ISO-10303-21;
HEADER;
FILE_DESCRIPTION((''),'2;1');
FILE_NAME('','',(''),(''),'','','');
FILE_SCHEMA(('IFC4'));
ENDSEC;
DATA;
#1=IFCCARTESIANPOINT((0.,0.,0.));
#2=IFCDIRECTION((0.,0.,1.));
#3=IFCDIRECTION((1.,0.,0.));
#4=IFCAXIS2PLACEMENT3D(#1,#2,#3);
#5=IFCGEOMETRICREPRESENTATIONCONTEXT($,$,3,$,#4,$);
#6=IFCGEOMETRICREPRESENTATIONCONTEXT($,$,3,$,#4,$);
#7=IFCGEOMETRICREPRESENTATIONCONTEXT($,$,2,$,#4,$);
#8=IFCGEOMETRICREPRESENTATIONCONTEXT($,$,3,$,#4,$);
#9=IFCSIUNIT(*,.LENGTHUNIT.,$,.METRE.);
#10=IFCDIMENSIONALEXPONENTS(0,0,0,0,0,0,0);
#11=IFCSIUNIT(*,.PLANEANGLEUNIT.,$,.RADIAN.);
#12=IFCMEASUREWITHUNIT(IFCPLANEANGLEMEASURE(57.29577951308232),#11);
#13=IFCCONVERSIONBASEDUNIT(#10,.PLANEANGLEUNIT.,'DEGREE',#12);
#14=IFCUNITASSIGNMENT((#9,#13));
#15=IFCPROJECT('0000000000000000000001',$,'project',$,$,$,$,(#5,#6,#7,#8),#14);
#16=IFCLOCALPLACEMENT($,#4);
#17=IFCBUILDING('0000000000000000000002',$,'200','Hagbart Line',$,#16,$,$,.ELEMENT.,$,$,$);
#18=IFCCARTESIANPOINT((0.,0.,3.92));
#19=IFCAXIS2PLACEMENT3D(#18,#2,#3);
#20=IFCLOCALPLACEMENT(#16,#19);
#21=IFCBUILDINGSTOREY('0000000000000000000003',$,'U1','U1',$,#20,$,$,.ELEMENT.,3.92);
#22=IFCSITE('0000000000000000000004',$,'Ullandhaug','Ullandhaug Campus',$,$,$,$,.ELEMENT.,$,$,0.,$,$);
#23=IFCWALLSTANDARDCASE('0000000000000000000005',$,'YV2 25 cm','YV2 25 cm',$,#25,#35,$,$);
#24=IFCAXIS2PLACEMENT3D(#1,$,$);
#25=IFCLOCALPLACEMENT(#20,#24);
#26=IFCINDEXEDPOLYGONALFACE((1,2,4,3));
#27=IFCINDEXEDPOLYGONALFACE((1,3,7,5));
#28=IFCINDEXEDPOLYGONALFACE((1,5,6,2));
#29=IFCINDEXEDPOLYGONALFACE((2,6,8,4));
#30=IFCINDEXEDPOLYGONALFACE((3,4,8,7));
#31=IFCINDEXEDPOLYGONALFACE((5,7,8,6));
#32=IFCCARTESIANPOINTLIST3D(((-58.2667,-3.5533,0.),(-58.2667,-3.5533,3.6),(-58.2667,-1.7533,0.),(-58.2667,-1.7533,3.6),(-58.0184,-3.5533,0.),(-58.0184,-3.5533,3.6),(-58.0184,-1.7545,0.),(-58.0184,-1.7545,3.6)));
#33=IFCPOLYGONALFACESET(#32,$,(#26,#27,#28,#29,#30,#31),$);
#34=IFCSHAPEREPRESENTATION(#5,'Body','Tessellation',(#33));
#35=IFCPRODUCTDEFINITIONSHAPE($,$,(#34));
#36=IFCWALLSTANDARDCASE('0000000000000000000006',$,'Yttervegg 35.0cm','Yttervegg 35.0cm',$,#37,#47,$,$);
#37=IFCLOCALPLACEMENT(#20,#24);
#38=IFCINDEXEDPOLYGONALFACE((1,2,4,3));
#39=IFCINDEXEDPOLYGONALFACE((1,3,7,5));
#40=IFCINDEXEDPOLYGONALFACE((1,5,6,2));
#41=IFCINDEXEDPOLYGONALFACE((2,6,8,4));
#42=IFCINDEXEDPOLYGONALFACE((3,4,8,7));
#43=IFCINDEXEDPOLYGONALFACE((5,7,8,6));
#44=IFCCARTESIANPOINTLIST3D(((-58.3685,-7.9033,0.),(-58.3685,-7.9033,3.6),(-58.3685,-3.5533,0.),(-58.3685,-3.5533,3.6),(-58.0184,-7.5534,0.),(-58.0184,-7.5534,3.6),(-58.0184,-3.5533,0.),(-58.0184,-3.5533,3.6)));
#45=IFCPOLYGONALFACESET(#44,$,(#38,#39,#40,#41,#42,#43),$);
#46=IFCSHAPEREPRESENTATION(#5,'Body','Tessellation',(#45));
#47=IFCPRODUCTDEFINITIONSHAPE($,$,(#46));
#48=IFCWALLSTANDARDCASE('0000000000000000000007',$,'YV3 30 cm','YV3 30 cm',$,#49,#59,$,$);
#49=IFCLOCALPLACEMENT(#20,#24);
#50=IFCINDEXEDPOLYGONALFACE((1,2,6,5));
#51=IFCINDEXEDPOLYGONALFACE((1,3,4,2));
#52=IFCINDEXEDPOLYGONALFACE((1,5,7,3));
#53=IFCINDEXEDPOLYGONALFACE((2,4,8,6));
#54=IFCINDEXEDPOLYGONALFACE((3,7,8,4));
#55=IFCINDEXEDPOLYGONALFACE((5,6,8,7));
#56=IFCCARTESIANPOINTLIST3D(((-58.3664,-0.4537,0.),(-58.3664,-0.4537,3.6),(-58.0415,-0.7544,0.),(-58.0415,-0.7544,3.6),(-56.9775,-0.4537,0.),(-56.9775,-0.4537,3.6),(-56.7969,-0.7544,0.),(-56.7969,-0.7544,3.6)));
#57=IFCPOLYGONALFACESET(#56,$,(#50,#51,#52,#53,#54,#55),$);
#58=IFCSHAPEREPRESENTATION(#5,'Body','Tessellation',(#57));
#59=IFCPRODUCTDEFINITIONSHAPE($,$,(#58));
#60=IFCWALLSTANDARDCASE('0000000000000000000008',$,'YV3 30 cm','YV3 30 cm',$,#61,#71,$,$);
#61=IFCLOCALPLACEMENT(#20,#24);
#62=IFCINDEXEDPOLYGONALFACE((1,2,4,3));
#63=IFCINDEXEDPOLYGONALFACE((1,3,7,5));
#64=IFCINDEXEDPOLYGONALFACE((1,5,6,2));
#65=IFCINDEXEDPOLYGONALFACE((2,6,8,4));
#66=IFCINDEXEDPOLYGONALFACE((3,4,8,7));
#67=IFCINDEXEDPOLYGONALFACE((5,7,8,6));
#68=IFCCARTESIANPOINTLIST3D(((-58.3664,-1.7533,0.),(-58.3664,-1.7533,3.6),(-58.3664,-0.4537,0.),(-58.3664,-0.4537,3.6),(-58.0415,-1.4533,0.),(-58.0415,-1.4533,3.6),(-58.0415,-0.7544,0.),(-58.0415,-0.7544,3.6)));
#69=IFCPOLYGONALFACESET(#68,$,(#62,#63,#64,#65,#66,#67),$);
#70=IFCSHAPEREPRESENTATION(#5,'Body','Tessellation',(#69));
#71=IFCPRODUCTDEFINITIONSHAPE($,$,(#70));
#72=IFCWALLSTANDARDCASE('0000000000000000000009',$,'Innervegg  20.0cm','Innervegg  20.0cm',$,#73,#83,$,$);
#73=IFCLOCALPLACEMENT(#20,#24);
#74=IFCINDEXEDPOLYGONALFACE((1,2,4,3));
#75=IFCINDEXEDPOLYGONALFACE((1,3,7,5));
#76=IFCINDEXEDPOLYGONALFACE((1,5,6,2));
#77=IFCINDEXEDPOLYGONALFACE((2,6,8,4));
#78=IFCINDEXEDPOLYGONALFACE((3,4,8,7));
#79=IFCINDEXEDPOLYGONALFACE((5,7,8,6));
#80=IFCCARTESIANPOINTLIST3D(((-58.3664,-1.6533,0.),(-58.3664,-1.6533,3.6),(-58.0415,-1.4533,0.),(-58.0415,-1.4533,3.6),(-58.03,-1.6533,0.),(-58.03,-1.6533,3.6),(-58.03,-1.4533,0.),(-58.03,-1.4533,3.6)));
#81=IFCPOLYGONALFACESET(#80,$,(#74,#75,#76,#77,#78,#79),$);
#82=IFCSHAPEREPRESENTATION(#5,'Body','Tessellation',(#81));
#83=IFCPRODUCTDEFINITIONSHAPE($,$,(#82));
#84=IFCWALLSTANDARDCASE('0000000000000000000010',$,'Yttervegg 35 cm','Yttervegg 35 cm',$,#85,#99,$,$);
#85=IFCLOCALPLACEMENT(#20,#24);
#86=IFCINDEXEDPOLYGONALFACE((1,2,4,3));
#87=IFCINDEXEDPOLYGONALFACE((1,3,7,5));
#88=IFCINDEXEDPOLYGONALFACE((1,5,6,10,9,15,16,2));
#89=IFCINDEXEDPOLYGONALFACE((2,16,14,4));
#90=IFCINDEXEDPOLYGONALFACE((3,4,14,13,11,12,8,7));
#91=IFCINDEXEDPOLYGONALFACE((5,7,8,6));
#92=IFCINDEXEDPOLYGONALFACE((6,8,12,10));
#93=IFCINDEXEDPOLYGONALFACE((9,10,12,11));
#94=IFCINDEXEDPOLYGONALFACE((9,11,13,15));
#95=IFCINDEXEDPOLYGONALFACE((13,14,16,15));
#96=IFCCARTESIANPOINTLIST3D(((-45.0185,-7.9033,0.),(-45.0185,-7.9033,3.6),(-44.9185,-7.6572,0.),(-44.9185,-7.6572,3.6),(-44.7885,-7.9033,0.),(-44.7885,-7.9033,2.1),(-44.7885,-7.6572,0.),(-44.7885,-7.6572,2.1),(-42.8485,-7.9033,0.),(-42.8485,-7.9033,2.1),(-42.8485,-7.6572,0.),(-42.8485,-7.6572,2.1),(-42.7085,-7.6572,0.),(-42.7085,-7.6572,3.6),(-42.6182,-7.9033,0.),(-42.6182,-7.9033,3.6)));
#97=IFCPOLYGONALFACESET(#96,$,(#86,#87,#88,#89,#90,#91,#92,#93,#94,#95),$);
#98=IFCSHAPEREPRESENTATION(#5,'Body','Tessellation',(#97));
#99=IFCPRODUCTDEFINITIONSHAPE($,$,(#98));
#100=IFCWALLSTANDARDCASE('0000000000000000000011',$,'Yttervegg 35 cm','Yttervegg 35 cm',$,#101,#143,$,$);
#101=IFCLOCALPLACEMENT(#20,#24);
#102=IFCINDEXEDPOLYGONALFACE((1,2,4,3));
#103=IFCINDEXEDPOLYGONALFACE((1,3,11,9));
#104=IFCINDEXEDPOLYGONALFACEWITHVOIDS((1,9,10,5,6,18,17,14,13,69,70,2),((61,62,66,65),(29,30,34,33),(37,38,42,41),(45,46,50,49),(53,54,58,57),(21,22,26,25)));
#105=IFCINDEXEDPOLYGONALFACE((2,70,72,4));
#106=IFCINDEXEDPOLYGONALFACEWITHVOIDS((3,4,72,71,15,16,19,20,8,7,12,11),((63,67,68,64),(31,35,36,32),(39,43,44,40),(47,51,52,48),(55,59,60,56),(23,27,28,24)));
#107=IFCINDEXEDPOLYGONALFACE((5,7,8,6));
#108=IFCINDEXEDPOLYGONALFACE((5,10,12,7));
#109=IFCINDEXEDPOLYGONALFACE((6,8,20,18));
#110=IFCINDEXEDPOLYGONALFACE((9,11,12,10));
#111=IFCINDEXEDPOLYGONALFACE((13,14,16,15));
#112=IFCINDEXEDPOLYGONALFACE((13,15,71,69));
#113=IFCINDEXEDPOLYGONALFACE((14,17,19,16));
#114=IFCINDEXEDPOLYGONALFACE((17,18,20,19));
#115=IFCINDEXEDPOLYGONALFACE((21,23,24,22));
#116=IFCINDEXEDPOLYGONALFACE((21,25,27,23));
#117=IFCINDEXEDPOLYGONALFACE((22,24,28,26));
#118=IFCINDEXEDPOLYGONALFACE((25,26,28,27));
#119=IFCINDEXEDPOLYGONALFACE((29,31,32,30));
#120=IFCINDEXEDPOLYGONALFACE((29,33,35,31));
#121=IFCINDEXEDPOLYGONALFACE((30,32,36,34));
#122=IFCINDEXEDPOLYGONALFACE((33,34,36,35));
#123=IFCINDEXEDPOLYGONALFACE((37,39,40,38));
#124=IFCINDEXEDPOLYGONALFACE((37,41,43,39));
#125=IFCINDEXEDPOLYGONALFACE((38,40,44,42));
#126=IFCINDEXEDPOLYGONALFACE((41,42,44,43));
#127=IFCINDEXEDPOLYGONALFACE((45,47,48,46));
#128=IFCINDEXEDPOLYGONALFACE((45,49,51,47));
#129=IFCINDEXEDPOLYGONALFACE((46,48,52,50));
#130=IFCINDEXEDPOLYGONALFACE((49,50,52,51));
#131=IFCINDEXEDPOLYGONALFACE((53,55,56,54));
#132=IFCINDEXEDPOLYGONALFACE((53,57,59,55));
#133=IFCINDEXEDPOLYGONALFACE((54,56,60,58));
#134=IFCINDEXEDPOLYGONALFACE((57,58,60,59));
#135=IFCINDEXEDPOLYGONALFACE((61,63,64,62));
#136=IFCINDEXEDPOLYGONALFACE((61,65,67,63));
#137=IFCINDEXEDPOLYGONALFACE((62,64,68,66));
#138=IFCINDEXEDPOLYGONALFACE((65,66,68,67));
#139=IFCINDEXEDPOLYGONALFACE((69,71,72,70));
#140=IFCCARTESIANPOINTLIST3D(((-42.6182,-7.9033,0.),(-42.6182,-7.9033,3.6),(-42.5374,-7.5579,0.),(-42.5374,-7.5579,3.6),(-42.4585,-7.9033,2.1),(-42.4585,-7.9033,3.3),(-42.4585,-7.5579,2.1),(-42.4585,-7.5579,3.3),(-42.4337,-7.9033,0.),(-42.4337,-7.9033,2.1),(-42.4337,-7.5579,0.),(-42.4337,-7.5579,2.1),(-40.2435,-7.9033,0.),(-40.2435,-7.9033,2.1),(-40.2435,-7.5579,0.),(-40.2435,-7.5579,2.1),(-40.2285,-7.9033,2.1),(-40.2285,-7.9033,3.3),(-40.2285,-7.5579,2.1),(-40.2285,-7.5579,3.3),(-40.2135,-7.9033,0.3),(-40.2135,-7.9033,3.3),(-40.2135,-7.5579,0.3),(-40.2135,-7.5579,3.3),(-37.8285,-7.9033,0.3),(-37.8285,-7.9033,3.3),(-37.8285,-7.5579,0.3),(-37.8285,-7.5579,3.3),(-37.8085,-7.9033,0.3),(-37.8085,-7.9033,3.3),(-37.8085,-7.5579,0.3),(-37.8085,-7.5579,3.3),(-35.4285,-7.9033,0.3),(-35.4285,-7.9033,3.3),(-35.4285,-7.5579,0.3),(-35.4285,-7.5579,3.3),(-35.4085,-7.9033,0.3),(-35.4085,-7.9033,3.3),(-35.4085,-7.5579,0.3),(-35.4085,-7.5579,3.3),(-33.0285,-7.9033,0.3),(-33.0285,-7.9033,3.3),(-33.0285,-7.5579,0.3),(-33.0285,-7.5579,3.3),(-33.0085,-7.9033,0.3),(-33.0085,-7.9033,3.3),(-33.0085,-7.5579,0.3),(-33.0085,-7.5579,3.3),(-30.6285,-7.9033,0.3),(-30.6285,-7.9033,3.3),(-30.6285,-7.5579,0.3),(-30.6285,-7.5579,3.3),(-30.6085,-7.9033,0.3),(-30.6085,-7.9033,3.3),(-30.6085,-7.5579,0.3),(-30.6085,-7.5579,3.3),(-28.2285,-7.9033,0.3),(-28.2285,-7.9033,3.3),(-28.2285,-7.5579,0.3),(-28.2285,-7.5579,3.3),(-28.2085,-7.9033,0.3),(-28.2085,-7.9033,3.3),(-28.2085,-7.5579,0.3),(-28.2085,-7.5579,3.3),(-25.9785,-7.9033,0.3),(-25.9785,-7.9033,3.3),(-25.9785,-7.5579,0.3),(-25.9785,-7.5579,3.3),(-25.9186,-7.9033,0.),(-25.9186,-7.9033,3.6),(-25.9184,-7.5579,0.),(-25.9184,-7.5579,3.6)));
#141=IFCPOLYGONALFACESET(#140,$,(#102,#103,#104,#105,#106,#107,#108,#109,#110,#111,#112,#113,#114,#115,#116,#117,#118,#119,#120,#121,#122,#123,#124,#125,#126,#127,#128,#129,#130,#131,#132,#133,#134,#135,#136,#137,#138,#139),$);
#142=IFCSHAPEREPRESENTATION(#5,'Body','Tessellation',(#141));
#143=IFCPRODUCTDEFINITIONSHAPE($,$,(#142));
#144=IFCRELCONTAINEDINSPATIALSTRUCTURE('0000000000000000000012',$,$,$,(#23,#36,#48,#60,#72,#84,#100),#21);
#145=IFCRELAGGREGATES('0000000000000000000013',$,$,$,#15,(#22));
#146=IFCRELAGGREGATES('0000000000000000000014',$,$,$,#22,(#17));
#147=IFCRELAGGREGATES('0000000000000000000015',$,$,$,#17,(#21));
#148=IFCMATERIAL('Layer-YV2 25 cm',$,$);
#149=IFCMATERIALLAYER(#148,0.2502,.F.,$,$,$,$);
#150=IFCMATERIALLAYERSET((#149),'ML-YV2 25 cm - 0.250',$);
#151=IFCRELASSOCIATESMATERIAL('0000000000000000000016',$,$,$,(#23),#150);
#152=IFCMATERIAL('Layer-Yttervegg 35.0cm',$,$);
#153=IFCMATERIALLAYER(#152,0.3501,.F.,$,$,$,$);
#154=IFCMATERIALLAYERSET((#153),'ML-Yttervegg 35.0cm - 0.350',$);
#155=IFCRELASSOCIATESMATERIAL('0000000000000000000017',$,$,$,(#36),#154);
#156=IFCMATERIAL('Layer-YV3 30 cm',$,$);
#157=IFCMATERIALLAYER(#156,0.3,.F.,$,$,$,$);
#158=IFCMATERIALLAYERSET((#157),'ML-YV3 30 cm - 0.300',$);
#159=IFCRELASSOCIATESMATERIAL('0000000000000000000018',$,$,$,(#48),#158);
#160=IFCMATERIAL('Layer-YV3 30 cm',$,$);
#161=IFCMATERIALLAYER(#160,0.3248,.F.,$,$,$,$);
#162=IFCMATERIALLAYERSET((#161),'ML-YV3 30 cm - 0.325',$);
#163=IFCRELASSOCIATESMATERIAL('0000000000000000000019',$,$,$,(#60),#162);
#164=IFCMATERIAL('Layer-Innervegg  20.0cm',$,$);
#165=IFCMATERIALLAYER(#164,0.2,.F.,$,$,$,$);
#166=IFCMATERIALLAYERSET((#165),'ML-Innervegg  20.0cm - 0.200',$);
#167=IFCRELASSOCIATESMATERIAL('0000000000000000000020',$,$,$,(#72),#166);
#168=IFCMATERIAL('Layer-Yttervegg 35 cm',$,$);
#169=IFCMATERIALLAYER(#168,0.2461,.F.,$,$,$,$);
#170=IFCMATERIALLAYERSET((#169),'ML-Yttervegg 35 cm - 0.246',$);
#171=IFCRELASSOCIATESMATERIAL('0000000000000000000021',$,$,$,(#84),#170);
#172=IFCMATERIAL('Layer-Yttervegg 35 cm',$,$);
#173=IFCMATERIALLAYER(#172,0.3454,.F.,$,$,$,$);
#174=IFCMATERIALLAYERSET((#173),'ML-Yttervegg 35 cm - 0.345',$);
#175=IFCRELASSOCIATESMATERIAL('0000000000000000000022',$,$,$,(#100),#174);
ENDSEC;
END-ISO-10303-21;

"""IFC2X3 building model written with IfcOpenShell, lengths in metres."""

from ifc_helpers import new_model, entity, si_unit, converted_unit, frame, origin_with_axes, place, context, project, spatial, polyline, outline, extrude, material, layer, layer_set, layer_usage, element, save


model = new_model("IFC2X3")

# Units and contexts
context_of_model_1 = context(None, 3, world=origin_with_axes())
context_of_model_2 = context(None, 3, world=origin_with_axes())
context_of_model_3 = context(None, 2, world=origin_with_axes())
context_of_model_4 = context(None, 3, world=origin_with_axes())
ifc_project = project(units=[si_unit("LENGTHUNIT", "METRE"), converted_unit("PLANEANGLEUNIT", "DEGREE", entity("IfcPlaneAngleMeasure", 57.29577951308232), si_unit("PLANEANGLEUNIT", "RADIAN"), dimensions=[0, 0, 0, 0, 0, 0, 0])], contexts=[context_of_model_1, context_of_model_2, context_of_model_3, context_of_model_4])

# Site, building, storey
site = spatial("IfcSite", under=ifc_project, Name="Ullandhaug", Description="Ullandhaug Campus", CompositionType="ELEMENT", RefElevation=0.0)
building_placement = place(None, origin_with_axes())
building = spatial("IfcBuilding", under=site, at=building_placement, Name="200", Description="Hagbart Line", CompositionType="ELEMENT")
storey_placement = place(building_placement, frame((0.0, 0.0, 3.92), z_axis=(0.0, 0.0, 1.0), x_axis=(1.0, 0.0, 0.0)))
storey = spatial("IfcBuildingStorey", under=building, at=storey_placement, Name="U1", Description="U1", CompositionType="ELEMENT", Elevation=3.92)

# Shared definitions
ifc_material_1 = material(Name="Layer-YV3 30 cm")
ifc_layer_1 = layer(ifc_material_1, 0.3, ventilated=False)
ifc_layer_set_1 = layer_set([ifc_layer_1], Name="ML-YV3 30 cm - 0.300")
ifc_layer_usage_1 = layer_usage(ifc_layer_set_1, "AXIS2", "POSITIVE", 0.0)
ifc_material_2 = material(Name="Layer-YV2 25 cm")
ifc_layer_2 = layer(ifc_material_2, 0.2502, ventilated=False)
ifc_layer_set_2 = layer_set([ifc_layer_2], Name="ML-YV2 25 cm - 0.250")
ifc_layer_usage_2 = layer_usage(ifc_layer_set_2, "AXIS2", "POSITIVE", 0.0)
ifc_material_3 = material(Name="Layer-Innervegg  20.0cm")
ifc_layer_3 = layer(ifc_material_3, 0.2, ventilated=False)
ifc_layer_set_3 = layer_set([ifc_layer_3], Name="ML-Innervegg  20.0cm - 0.200")
ifc_layer_usage_3 = layer_usage(ifc_layer_set_3, "AXIS2", "POSITIVE", 0.0)

# Walls
wall_1_placement = place(storey_placement, frame((-58.2667, -1.7533, 0.0), z_axis=(0.0, 0.0, 1.0), x_axis=(0.0, -1.0, 0.0)))
element("IfcWallStandardCase", 1, at=wall_1_placement, inside=storey, material=ifc_layer_usage_2, Name="YV2 25 cm", Description="YV2 25 cm", context=context_of_model_1, shape_type="SweptSolid", body=[
    extrude(outline(polyline([(0.0, 0.0), (1.8, 0.0), (1.8, 0.2483), (0.0012, 0.2483), (0.0, 0.0)])), frame((0.0, 0.0, 0.0), z_axis=(0.0, 0.0, 1.0), x_axis=(1.0, 0.0, 0.0)), (0.0, 0.0, 1.0), 3.6),
])
ifc_material_4 = material(Name="Layer-Yttervegg 35.0cm")
ifc_layer_4 = layer(ifc_material_4, 0.3501, ventilated=False)
ifc_layer_set_4 = layer_set([ifc_layer_4], Name="ML-Yttervegg 35.0cm - 0.350")
ifc_layer_usage_4 = layer_usage(ifc_layer_set_4, "AXIS2", "POSITIVE", 0.0)
wall_2_placement = place(storey_placement, frame((-58.3685, -3.5533, 0.0), z_axis=(0.0, 0.0, 1.0), x_axis=(0.0, -1.0, 0.0)))
element("IfcWallStandardCase", 2, at=wall_2_placement, inside=storey, material=ifc_layer_usage_4, Name="Yttervegg 35.0cm", Description="Yttervegg 35.0cm", context=context_of_model_1, shape_type="SweptSolid", body=[
    extrude(outline(polyline([(0.0, 0.0), (4.35, 0.0), (4.0001, 0.3501), (0.0, 0.3501), (0.0, 0.0)])), frame((0.0, 0.0, 0.0), z_axis=(0.0, 0.0, 1.0), x_axis=(1.0, 0.0, 0.0)), (0.0, 0.0, 1.0), 3.6),
])
wall_3_placement = place(storey_placement, frame((-56.9775, -0.4537, 0.0), z_axis=(0.0, 0.0, 1.0), x_axis=(-1.0, 0.0, 0.0)))
element("IfcWallStandardCase", 3, at=wall_3_placement, inside=storey, material=ifc_layer_usage_1, Name="YV3 30 cm", Description="YV3 30 cm", context=context_of_model_1, shape_type="SweptSolid", body=[
    extrude(outline(polyline([(0.0, 0.0), (1.3889, 0.0), (1.0641, 0.3008), (-0.1805, 0.3008), (0.0, 0.0)])), frame((0.0, 0.0, 0.0), z_axis=(0.0, 0.0, 1.0), x_axis=(1.0, 0.0, 0.0)), (0.0, 0.0, 1.0), 3.6),
])
ifc_material_5 = material(Name="Layer-YV3 30 cm")
ifc_layer_5 = layer(ifc_material_5, 0.3248, ventilated=False)
ifc_layer_set_5 = layer_set([ifc_layer_5], Name="ML-YV3 30 cm - 0.325")
ifc_layer_usage_5 = layer_usage(ifc_layer_set_5, "AXIS2", "POSITIVE", 0.0)
wall_4_placement = place(storey_placement, frame((-58.3664, -0.4537, 0.0), z_axis=(0.0, 0.0, 1.0), x_axis=(0.0, -1.0, 0.0)))
element("IfcWallStandardCase", 4, at=wall_4_placement, inside=storey, material=ifc_layer_usage_5, Name="YV3 30 cm", Description="YV3 30 cm", context=context_of_model_1, shape_type="SweptSolid", body=[
    extrude(outline(polyline([(0.0, 0.0), (1.2996, 0.0), (0.9996, 0.3248), (0.3008, 0.3248), (0.0, 0.0)])), frame((0.0, 0.0, 0.0), z_axis=(0.0, 0.0, 1.0), x_axis=(1.0, 0.0, 0.0)), (0.0, 0.0, 1.0), 3.6),
])
wall_5_placement = place(storey_placement, frame((-58.3664, -1.6533, 0.0), z_axis=(0.0, 0.0, 1.0), x_axis=(1.0, 0.0, 0.0)))
element("IfcWallStandardCase", 5, at=wall_5_placement, inside=storey, material=ifc_layer_usage_3, Name="Innervegg  20.0cm", Description="Innervegg  20.0cm", context=context_of_model_1, shape_type="SweptSolid", body=[
    extrude(outline(polyline([(0.0, 0.0), (0.3364, 0.0), (0.3364, 0.2), (0.3248, 0.2), (0.0, 0.0)])), origin_with_axes(), (0.0, 0.0, 1.0), 3.6),
])

# Wall, opening
ifc_material_6 = material(Name="Layer-Yttervegg 35 cm")
ifc_layer_6 = layer(ifc_material_6, 0.2461, ventilated=False)
ifc_layer_set_6 = layer_set([ifc_layer_6], Name="ML-Yttervegg 35 cm - 0.246")
ifc_layer_usage_6 = layer_usage(ifc_layer_set_6, "AXIS2", "POSITIVE", 0.0)
wall_6_placement = place(storey_placement, frame((-45.0185, -7.9033, 0.0), z_axis=(0.0, 0.0, 1.0), x_axis=(1.0, 0.0, 0.0)))
wall_6 = element("IfcWallStandardCase", 6, at=wall_6_placement, inside=storey, material=ifc_layer_usage_6, Name="Yttervegg 35 cm", Description="Yttervegg 35 cm", context=context_of_model_1, shape_type="SweptSolid", body=[
    extrude(outline(polyline([(0.0, 0.0), (2.4003, 0.0), (2.31, 0.2461), (0.1, 0.2461), (0.0, 0.0)])), origin_with_axes(), (0.0, 0.0, 1.0), 3.6),
])
opening_1_placement = place(wall_6_placement, frame((0.2299, 0.2461, 0.0), z_axis=(0.0, 0.0, 1.0), x_axis=(1.0, 0.0, 0.0)))
element("IfcOpeningElement", 7, at=opening_1_placement, cuts=wall_6, context=context_of_model_1, shape_type="SweptSolid", body=[
    extrude(outline(polyline([(0.0, 0.0), (2.1, 0.0), (2.1, 1.94), (0.0, 1.94), (0.0, 0.0)])), frame((0.0, 0.0, 0.0), z_axis=(0.0, 1.0, 0.0), x_axis=(0.0, 0.0, 1.0)), (0.0, 0.0, -1.0), 0.2461),
])

# Wall, openings
ifc_material_7 = material(Name="Layer-Yttervegg 35 cm")
ifc_layer_7 = layer(ifc_material_7, 0.3454, ventilated=False)
ifc_layer_set_7 = layer_set([ifc_layer_7], Name="ML-Yttervegg 35 cm - 0.345")
ifc_layer_usage_7 = layer_usage(ifc_layer_set_7, "AXIS2", "POSITIVE", 0.0)
wall_7_placement = place(storey_placement, frame((-42.6182, -7.9033, 0.0), z_axis=(0.0, 0.0, 1.0), x_axis=(1.0, 0.0, 0.0)))
wall_7 = element("IfcWallStandardCase", 8, at=wall_7_placement, inside=storey, material=ifc_layer_usage_7, Name="Yttervegg 35 cm", Description="Yttervegg 35 cm", context=context_of_model_1, shape_type="SweptSolid", body=[
    extrude(outline(polyline([(0.0, 0.0), (16.6996, 0.0), (16.6998, 0.3454), (0.0808, 0.3454), (0.0, 0.0)])), origin_with_axes(), (0.0, 0.0, 1.0), 3.6),
])
opening_2_placement = place(wall_7_placement, frame((0.1845, 0.3454, 0.0), z_axis=(0.0, 0.0, 1.0), x_axis=(1.0, 0.0, 0.0)))
element("IfcOpeningElement", 9, at=opening_2_placement, cuts=wall_7, context=context_of_model_1, shape_type="SweptSolid", body=[
    extrude(outline(polyline([(0.0, 0.0), (2.1, 0.0), (2.1, 2.1902), (0.0, 2.1902), (0.0, 0.0)])), frame((0.0, 0.0, 0.0), z_axis=(0.0, 1.0, 0.0), x_axis=(0.0, 0.0, 1.0)), (0.0, 0.0, -1.0), 0.3454),
])
opening_3_placement = place(wall_7_placement, frame((0.1597, 0.3454, 2.1), z_axis=(0.0, 0.0, 1.0), x_axis=(1.0, 0.0, 0.0)))
element("IfcOpeningElement", 10, at=opening_3_placement, cuts=wall_7, context=context_of_model_1, shape_type="SweptSolid", body=[
    extrude(outline(polyline([(0.0, 0.0), (1.2, 0.0), (1.2, 2.23), (0.0, 2.23), (0.0, 0.0)])), frame((0.0, 0.0, 0.0), z_axis=(0.0, 1.0, 0.0), x_axis=(0.0, 0.0, 1.0)), (0.0, 0.0, -1.0), 0.3454),
])
opening_4_placement = place(wall_7_placement, frame((2.4047, 0.3454, 0.3), z_axis=(0.0, 0.0, 1.0), x_axis=(1.0, 0.0, 0.0)))
element("IfcOpeningElement", 11, at=opening_4_placement, cuts=wall_7, context=context_of_model_1, shape_type="SweptSolid", body=[
    extrude(outline(polyline([(0.0, 0.0), (3.0, 0.0), (3.0, 2.385), (0.0, 2.385), (0.0, 0.0)])), frame((0.0, 0.0, 0.0), z_axis=(0.0, 1.0, 0.0), x_axis=(0.0, 0.0, 1.0)), (0.0, 0.0, -1.0), 0.3454),
])
opening_5_placement = place(wall_7_placement, frame((4.8097, 0.3454, 0.3), z_axis=(0.0, 0.0, 1.0), x_axis=(1.0, 0.0, 0.0)))
element("IfcOpeningElement", 12, at=opening_5_placement, cuts=wall_7, context=context_of_model_1, shape_type="SweptSolid", body=[
    extrude(outline(polyline([(0.0, 0.0), (3.0, 0.0), (3.0, 2.38), (0.0, 2.38), (0.0, 0.0)])), frame((0.0, 0.0, 0.0), z_axis=(0.0, 1.0, 0.0), x_axis=(0.0, 0.0, 1.0)), (0.0, 0.0, -1.0), 0.3454),
])
opening_6_placement = place(wall_7_placement, frame((7.2097, 0.3454, 0.3), z_axis=(0.0, 0.0, 1.0), x_axis=(1.0, 0.0, 0.0)))
element("IfcOpeningElement", 13, at=opening_6_placement, cuts=wall_7, context=context_of_model_1, shape_type="SweptSolid", body=[
    extrude(outline(polyline([(0.0, 0.0), (3.0, 0.0), (3.0, 2.38), (0.0, 2.38), (0.0, 0.0)])), frame((0.0, 0.0, 0.0), z_axis=(0.0, 1.0, 0.0), x_axis=(0.0, 0.0, 1.0)), (0.0, 0.0, -1.0), 0.3454),
])
opening_7_placement = place(wall_7_placement, frame((9.6097, 0.3454, 0.3), z_axis=(0.0, 0.0, 1.0), x_axis=(1.0, 0.0, 0.0)))
element("IfcOpeningElement", 14, at=opening_7_placement, cuts=wall_7, context=context_of_model_1, shape_type="SweptSolid", body=[
    extrude(outline(polyline([(0.0, 0.0), (3.0, 0.0), (3.0, 2.38), (0.0, 2.38), (0.0, 0.0)])), frame((0.0, 0.0, 0.0), z_axis=(0.0, 1.0, 0.0), x_axis=(0.0, 0.0, 1.0)), (0.0, 0.0, -1.0), 0.3454),
])
opening_8_placement = place(wall_7_placement, frame((12.0097, 0.3454, 0.3), z_axis=(0.0, 0.0, 1.0), x_axis=(1.0, 0.0, 0.0)))
element("IfcOpeningElement", 15, at=opening_8_placement, cuts=wall_7, context=context_of_model_1, shape_type="SweptSolid", body=[
    extrude(outline(polyline([(0.0, 0.0), (3.0, 0.0), (3.0, 2.38), (0.0, 2.38), (0.0, 0.0)])), frame((0.0, 0.0, 0.0), z_axis=(0.0, 1.0, 0.0), x_axis=(0.0, 0.0, 1.0)), (0.0, 0.0, -1.0), 0.3454),
])
opening_9_placement = place(wall_7_placement, frame((14.4097, 0.3454, 0.3), z_axis=(0.0, 0.0, 1.0), x_axis=(1.0, 0.0, 0.0)))
element("IfcOpeningElement", 16, at=opening_9_placement, cuts=wall_7, context=context_of_model_1, shape_type="SweptSolid", body=[
    extrude(outline(polyline([(0.0, 0.0), (3.0, 0.0), (3.0, 2.23), (0.0, 2.23), (0.0, 0.0)])), frame((0.0, 0.0, 0.0), z_axis=(0.0, 1.0, 0.0), x_axis=(0.0, 0.0, 1.0)), (0.0, 0.0, -1.0), 0.3454),
])

save(model, "model.ifc")
